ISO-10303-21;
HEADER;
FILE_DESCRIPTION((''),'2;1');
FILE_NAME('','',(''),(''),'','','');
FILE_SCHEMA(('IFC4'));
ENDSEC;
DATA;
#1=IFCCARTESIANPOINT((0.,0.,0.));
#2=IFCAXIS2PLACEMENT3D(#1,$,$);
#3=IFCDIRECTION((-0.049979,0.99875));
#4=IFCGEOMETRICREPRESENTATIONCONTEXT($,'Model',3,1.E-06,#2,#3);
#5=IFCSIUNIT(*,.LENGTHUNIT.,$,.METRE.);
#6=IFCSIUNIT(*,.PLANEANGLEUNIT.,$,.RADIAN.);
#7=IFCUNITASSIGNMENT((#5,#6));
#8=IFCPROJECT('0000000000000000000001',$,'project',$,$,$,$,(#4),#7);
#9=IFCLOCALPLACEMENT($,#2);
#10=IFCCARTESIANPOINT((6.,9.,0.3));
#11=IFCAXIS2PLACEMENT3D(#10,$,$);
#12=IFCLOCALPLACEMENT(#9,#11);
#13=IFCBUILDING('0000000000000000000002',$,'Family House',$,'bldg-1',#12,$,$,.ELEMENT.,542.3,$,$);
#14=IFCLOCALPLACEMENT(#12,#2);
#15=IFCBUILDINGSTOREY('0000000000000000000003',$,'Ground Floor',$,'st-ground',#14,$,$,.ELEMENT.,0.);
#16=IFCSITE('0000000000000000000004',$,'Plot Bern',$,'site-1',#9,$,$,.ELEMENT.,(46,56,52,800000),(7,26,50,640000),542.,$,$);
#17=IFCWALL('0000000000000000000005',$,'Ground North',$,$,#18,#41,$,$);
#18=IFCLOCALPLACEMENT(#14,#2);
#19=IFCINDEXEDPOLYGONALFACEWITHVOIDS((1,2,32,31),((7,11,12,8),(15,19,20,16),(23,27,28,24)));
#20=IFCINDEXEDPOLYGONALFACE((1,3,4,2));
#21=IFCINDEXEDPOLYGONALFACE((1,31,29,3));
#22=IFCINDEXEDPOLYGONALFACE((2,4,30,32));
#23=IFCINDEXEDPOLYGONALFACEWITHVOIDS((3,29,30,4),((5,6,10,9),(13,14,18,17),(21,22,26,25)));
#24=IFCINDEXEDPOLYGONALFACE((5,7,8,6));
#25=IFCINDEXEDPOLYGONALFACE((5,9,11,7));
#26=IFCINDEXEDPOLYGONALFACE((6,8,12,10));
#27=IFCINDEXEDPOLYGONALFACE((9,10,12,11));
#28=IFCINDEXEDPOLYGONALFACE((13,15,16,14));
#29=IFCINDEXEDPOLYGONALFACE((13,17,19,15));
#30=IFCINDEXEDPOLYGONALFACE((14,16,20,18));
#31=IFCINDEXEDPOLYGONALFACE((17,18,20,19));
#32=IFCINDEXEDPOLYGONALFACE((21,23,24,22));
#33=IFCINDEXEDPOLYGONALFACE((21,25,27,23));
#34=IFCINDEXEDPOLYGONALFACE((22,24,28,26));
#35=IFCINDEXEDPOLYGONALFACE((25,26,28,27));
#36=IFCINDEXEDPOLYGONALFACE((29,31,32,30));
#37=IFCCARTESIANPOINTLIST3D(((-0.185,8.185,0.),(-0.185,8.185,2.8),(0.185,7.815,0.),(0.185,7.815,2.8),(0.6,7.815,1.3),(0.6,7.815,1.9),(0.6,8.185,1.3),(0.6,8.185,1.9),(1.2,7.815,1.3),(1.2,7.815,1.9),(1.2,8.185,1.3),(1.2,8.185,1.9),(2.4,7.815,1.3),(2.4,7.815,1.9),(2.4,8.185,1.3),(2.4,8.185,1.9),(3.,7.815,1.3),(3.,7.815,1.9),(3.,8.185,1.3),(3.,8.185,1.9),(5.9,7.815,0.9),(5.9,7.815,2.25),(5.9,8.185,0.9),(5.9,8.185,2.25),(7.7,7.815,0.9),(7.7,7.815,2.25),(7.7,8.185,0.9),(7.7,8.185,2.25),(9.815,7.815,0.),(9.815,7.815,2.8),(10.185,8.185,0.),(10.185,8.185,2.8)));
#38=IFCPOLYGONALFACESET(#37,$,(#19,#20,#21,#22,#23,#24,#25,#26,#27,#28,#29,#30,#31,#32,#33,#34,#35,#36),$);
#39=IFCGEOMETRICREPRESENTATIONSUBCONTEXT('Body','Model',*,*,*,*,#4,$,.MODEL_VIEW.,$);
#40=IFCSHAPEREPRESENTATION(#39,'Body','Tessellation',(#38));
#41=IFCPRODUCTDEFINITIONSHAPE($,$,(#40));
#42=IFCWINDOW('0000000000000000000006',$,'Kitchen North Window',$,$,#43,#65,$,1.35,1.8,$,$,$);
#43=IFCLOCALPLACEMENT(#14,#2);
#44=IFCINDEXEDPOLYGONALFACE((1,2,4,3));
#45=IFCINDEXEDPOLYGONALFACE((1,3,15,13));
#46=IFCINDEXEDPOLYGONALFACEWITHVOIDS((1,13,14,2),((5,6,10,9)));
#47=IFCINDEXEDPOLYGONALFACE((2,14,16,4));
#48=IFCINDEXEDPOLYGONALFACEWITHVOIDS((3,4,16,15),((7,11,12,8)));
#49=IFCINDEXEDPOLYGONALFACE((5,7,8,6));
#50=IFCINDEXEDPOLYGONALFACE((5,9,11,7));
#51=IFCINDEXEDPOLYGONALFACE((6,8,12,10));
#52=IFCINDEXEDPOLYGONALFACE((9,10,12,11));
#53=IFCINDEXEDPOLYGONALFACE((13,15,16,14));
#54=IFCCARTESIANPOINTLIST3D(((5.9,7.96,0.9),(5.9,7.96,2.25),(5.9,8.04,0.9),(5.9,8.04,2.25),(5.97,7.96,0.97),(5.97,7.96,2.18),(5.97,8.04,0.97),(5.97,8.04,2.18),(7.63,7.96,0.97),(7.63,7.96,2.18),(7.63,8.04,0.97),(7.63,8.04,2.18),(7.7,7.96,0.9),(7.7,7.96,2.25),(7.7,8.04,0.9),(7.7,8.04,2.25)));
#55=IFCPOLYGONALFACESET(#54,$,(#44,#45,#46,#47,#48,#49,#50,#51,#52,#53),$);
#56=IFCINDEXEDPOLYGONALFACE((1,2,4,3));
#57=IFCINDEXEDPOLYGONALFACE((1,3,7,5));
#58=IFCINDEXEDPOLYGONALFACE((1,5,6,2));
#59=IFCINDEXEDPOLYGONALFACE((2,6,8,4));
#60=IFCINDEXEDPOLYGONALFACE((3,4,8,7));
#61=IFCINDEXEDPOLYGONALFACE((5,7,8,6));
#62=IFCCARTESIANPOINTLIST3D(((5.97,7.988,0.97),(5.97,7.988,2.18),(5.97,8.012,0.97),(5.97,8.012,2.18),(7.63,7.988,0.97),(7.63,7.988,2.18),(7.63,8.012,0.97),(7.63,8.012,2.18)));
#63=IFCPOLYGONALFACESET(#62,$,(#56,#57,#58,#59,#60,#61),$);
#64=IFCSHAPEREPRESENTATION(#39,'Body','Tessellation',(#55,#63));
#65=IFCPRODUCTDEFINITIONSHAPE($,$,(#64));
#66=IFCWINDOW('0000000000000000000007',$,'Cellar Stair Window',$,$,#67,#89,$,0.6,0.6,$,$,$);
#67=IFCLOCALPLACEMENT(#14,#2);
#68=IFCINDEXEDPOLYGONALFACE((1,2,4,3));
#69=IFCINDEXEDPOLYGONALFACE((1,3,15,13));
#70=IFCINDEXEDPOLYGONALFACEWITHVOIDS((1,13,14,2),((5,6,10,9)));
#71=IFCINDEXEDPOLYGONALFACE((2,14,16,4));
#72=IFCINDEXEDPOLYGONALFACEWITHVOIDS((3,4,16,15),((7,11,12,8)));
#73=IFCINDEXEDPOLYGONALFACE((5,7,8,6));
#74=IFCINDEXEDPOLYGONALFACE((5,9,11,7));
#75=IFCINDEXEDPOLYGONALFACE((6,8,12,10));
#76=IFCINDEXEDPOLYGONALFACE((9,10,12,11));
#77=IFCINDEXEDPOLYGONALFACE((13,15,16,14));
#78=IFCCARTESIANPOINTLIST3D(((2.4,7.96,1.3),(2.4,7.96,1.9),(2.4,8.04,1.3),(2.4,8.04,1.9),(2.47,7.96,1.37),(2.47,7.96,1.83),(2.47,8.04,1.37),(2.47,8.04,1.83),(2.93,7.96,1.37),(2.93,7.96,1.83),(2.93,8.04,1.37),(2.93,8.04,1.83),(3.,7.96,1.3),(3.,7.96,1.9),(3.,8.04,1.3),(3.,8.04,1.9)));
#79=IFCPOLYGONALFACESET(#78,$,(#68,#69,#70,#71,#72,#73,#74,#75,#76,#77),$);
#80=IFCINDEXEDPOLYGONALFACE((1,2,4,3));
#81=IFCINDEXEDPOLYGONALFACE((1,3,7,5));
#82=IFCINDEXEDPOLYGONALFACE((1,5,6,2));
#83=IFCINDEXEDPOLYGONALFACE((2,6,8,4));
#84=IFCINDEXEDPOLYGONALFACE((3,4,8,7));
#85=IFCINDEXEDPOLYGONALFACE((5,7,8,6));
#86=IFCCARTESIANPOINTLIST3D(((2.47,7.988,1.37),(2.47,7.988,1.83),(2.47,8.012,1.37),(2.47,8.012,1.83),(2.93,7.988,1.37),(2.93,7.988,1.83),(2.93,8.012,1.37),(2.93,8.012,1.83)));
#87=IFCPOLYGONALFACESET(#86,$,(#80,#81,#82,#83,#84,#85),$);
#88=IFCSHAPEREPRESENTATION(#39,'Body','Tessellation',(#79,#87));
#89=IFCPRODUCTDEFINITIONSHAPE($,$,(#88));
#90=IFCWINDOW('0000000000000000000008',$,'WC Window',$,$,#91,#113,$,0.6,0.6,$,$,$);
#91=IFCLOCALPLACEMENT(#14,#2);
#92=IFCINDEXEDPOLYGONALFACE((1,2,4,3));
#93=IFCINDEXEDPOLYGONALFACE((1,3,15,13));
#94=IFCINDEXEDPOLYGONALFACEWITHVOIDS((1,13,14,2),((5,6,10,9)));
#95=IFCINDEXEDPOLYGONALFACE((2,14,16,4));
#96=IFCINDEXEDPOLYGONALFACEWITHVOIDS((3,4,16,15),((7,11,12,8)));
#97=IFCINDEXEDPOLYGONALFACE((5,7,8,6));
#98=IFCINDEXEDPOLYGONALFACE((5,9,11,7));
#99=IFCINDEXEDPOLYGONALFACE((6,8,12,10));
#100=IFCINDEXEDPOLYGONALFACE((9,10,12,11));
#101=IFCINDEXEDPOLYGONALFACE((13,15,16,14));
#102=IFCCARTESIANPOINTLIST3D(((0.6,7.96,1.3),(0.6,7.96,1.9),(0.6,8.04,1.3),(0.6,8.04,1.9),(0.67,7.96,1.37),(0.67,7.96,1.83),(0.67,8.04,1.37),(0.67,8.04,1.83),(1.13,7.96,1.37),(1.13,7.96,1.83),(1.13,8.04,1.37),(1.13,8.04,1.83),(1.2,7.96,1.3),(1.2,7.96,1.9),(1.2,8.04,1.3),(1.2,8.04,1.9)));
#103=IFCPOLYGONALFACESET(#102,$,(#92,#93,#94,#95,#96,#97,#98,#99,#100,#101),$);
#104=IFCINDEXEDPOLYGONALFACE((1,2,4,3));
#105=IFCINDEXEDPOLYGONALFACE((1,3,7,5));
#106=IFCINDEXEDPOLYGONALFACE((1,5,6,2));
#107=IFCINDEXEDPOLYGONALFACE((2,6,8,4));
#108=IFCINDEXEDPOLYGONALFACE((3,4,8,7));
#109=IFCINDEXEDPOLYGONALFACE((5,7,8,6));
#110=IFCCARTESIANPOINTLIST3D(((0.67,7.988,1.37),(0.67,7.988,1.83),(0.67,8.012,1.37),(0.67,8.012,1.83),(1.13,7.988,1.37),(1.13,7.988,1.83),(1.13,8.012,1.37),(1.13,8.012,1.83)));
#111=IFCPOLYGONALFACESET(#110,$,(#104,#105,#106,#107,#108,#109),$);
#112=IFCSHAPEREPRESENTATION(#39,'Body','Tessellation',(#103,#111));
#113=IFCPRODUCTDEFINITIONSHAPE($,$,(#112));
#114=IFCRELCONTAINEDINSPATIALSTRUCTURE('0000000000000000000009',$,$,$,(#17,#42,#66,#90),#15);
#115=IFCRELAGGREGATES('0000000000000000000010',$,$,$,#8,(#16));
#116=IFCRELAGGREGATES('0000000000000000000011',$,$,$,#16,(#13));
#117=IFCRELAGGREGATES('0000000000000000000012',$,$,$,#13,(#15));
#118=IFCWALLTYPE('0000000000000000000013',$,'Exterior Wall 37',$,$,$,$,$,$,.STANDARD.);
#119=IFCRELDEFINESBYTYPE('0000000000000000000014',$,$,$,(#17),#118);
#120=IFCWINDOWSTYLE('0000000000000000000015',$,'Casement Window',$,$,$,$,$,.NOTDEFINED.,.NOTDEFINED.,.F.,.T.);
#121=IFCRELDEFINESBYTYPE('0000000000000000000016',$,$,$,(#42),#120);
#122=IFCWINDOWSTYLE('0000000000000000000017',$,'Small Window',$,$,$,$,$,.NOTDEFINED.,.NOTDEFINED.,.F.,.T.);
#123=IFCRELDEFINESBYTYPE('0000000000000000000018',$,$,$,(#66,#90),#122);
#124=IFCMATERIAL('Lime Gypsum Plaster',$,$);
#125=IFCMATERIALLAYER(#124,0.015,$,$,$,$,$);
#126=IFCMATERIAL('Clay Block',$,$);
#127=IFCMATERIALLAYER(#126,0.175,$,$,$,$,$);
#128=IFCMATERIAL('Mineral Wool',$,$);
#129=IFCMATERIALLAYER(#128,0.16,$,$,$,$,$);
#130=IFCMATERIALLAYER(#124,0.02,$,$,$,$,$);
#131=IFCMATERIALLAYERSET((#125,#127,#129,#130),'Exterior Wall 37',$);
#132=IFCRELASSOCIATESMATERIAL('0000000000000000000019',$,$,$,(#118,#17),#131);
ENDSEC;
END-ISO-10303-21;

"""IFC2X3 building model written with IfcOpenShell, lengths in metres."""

from ifc_helpers import new_model, si_unit, direction, frame, frame_2d, origin, origin_2d, place, context, subcontext, project, spatial, polyline, rectangle, outline, extrude, material, layer, layer_set, layer_usage, type_object, element, fill, save


model = new_model("IFC2X3")

# Units and contexts
model_context = context("Model", 3, precision=1e-06, world=origin(), true_north=direction((-0.049979, 0.99875)))
body_context = subcontext(model_context, "Body", "Model", "MODEL_VIEW")
ifc_project = project(units=[si_unit("LENGTHUNIT", "METRE"), si_unit("PLANEANGLEUNIT", "RADIAN")], contexts=[model_context])

# Site, building, storey
site_placement = place(None, origin())
site = spatial("IfcSite", under=ifc_project, at=site_placement, Name="Plot Bern", ObjectType="site-1", CompositionType="ELEMENT", RefLatitude=(46, 56, 52, 800000), RefLongitude=(7, 26, 50, 640000), RefElevation=542.0)
building_placement = place(site_placement, frame((6.0, 9.0, 0.3)))
building = spatial("IfcBuilding", under=site, at=building_placement, Name="Family House", ObjectType="bldg-1", CompositionType="ELEMENT", ElevationOfRefHeight=542.3)
storey_placement = place(building_placement, origin())
storey = spatial("IfcBuildingStorey", under=building, at=storey_placement, Name="Ground Floor", ObjectType="st-ground", CompositionType="ELEMENT", Elevation=0.0)

# Shared definitions
ifc_material_1 = material(Name="Mineral Wool")

# Shared definitions
ifc_material_2 = material(Name="Lime Gypsum Plaster")
ifc_layer_1 = layer(ifc_material_2, 0.015)
ifc_material_3 = material(Name="Clay Block")
ifc_layer_2 = layer(ifc_material_3, 0.175)
ifc_layer_3 = layer(ifc_material_1, 0.16)
ifc_layer_4 = layer(ifc_material_2, 0.02)
ifc_layer_set_1 = layer_set([ifc_layer_1, ifc_layer_2, ifc_layer_3, ifc_layer_4], Name="Exterior Wall 37")
wall_type_1 = type_object("IfcWallType", Name="Exterior Wall 37", PredefinedType="STANDARD", material=ifc_layer_set_1)

# Shared definitions
window_style_1 = type_object("IfcWindowStyle", Name="Casement Window", ConstructionType="NOTDEFINED", OperationType="NOTDEFINED", ParameterTakesPrecedence=False, Sizeable=True)

# Wall, openings, windows
ifc_layer_usage_1 = layer_usage(ifc_layer_set_1, "AXIS2", "NEGATIVE", 0.185)
wall_1_placement = place(storey_placement, origin())
wall_1 = element("IfcWall", 1, at=wall_1_placement, inside=storey, type_object=wall_type_1, material=ifc_layer_usage_1, Name="Ground North", context=body_context, shape_type="SweptSolid", body=[
    extrude(outline(polyline([(10.185, 8.185), (-0.185, 8.185), (0.185, 7.815), (9.815, 7.815), (10.185, 8.185)])), origin(), (0.0, 0.0, 1.0), 2.8),
])
opening_1_placement = place(wall_1_placement, frame((2.7, 8.0, 1.3), z_axis=(0.0, 0.0, 1.0), x_axis=(-1.0, 0.0, 0.0)))
opening_1 = element("IfcOpeningElement", 2, at=opening_1_placement, cuts=wall_1, context=body_context, shape_type="SweptSolid", body=[
    extrude(rectangle(XDim=0.6, YDim=0.37, at=origin_2d()), origin(), (0.0, 0.0, 1.0), 0.6),
])
opening_2_placement = place(wall_1_placement, frame((6.8, 8.0, 0.9), z_axis=(0.0, 0.0, 1.0), x_axis=(-1.0, 0.0, 0.0)))
opening_2 = element("IfcOpeningElement", 3, at=opening_2_placement, cuts=wall_1, context=body_context, shape_type="SweptSolid", body=[
    extrude(rectangle(XDim=1.8, YDim=0.37, at=origin_2d()), origin(), (0.0, 0.0, 1.0), 1.35),
])
opening_3_placement = place(wall_1_placement, frame((0.9, 8.0, 1.3), z_axis=(0.0, 0.0, 1.0), x_axis=(-1.0, 0.0, 0.0)))
opening_3 = element("IfcOpeningElement", 4, at=opening_3_placement, cuts=wall_1, context=body_context, shape_type="SweptSolid", body=[
    extrude(rectangle(XDim=0.6, YDim=0.37, at=origin_2d()), origin(), (0.0, 0.0, 1.0), 0.6),
])
window_1_placement = place(opening_2_placement, frame((0.0, 0.0, 0.0), z_axis=(0.0, -1.0, 0.0), x_axis=(1.0, 0.0, 0.0)))
window_1 = element("IfcWindow", 5, at=window_1_placement, inside=storey, type_object=window_style_1, Name="Kitchen North Window", OverallHeight=1.35, OverallWidth=1.8, context=body_context, shape_type="SweptSolid", body=[
    extrude(outline(polyline([(-0.9, 0.0), (0.9, 0.0), (0.9, 1.35), (-0.9, 1.35), (-0.9, 0.0)]), holes=[polyline([(-0.83, 0.07), (0.83, 0.07), (0.83, 1.28), (-0.83, 1.28), (-0.83, 0.07)])]), frame((0.0, 0.0, -0.04)), (0.0, 0.0, 1.0), 0.08),
    extrude(rectangle(XDim=1.66, YDim=1.21, at=frame_2d((0.0, 0.675))), frame((0.0, 0.0, -0.012)), (0.0, 0.0, 1.0), 0.024),
])
fill(opening_2, window_1)
window_style_2 = type_object("IfcWindowStyle", Name="Small Window", ConstructionType="NOTDEFINED", OperationType="NOTDEFINED", ParameterTakesPrecedence=False, Sizeable=True)
window_2_placement = place(opening_1_placement, frame((0.0, 0.0, 0.0), z_axis=(0.0, -1.0, 0.0), x_axis=(1.0, 0.0, 0.0)))
window_2 = element("IfcWindow", 6, at=window_2_placement, inside=storey, type_object=window_style_2, Name="Cellar Stair Window", OverallHeight=0.6, OverallWidth=0.6, context=body_context, shape_type="SweptSolid", body=[
    extrude(outline(polyline([(-0.3, 0.0), (0.3, 0.0), (0.3, 0.6), (-0.3, 0.6), (-0.3, 0.0)]), holes=[polyline([(-0.23, 0.07), (0.23, 0.07), (0.23, 0.53), (-0.23, 0.53), (-0.23, 0.07)])]), frame((0.0, 0.0, -0.04)), (0.0, 0.0, 1.0), 0.08),
    extrude(rectangle(XDim=0.46, YDim=0.46, at=frame_2d((0.0, 0.3))), frame((0.0, 0.0, -0.012)), (0.0, 0.0, 1.0), 0.024),
])
fill(opening_1, window_2)
window_3_placement = place(opening_3_placement, frame((0.0, 0.0, 0.0), z_axis=(0.0, -1.0, 0.0), x_axis=(1.0, 0.0, 0.0)))
window_3 = element("IfcWindow", 7, at=window_3_placement, inside=storey, type_object=window_style_2, Name="WC Window", OverallHeight=0.6, OverallWidth=0.6, context=body_context, shape_type="SweptSolid", body=[
    extrude(outline(polyline([(-0.3, 0.0), (0.3, 0.0), (0.3, 0.6), (-0.3, 0.6), (-0.3, 0.0)]), holes=[polyline([(-0.23, 0.07), (0.23, 0.07), (0.23, 0.53), (-0.23, 0.53), (-0.23, 0.07)])]), frame((0.0, 0.0, -0.04)), (0.0, 0.0, 1.0), 0.08),
    extrude(rectangle(XDim=0.46, YDim=0.46, at=frame_2d((0.0, 0.3))), frame((0.0, 0.0, -0.012)), (0.0, 0.0, 1.0), 0.024),
])
fill(opening_3, window_3)

save(model, "model.ifc")
